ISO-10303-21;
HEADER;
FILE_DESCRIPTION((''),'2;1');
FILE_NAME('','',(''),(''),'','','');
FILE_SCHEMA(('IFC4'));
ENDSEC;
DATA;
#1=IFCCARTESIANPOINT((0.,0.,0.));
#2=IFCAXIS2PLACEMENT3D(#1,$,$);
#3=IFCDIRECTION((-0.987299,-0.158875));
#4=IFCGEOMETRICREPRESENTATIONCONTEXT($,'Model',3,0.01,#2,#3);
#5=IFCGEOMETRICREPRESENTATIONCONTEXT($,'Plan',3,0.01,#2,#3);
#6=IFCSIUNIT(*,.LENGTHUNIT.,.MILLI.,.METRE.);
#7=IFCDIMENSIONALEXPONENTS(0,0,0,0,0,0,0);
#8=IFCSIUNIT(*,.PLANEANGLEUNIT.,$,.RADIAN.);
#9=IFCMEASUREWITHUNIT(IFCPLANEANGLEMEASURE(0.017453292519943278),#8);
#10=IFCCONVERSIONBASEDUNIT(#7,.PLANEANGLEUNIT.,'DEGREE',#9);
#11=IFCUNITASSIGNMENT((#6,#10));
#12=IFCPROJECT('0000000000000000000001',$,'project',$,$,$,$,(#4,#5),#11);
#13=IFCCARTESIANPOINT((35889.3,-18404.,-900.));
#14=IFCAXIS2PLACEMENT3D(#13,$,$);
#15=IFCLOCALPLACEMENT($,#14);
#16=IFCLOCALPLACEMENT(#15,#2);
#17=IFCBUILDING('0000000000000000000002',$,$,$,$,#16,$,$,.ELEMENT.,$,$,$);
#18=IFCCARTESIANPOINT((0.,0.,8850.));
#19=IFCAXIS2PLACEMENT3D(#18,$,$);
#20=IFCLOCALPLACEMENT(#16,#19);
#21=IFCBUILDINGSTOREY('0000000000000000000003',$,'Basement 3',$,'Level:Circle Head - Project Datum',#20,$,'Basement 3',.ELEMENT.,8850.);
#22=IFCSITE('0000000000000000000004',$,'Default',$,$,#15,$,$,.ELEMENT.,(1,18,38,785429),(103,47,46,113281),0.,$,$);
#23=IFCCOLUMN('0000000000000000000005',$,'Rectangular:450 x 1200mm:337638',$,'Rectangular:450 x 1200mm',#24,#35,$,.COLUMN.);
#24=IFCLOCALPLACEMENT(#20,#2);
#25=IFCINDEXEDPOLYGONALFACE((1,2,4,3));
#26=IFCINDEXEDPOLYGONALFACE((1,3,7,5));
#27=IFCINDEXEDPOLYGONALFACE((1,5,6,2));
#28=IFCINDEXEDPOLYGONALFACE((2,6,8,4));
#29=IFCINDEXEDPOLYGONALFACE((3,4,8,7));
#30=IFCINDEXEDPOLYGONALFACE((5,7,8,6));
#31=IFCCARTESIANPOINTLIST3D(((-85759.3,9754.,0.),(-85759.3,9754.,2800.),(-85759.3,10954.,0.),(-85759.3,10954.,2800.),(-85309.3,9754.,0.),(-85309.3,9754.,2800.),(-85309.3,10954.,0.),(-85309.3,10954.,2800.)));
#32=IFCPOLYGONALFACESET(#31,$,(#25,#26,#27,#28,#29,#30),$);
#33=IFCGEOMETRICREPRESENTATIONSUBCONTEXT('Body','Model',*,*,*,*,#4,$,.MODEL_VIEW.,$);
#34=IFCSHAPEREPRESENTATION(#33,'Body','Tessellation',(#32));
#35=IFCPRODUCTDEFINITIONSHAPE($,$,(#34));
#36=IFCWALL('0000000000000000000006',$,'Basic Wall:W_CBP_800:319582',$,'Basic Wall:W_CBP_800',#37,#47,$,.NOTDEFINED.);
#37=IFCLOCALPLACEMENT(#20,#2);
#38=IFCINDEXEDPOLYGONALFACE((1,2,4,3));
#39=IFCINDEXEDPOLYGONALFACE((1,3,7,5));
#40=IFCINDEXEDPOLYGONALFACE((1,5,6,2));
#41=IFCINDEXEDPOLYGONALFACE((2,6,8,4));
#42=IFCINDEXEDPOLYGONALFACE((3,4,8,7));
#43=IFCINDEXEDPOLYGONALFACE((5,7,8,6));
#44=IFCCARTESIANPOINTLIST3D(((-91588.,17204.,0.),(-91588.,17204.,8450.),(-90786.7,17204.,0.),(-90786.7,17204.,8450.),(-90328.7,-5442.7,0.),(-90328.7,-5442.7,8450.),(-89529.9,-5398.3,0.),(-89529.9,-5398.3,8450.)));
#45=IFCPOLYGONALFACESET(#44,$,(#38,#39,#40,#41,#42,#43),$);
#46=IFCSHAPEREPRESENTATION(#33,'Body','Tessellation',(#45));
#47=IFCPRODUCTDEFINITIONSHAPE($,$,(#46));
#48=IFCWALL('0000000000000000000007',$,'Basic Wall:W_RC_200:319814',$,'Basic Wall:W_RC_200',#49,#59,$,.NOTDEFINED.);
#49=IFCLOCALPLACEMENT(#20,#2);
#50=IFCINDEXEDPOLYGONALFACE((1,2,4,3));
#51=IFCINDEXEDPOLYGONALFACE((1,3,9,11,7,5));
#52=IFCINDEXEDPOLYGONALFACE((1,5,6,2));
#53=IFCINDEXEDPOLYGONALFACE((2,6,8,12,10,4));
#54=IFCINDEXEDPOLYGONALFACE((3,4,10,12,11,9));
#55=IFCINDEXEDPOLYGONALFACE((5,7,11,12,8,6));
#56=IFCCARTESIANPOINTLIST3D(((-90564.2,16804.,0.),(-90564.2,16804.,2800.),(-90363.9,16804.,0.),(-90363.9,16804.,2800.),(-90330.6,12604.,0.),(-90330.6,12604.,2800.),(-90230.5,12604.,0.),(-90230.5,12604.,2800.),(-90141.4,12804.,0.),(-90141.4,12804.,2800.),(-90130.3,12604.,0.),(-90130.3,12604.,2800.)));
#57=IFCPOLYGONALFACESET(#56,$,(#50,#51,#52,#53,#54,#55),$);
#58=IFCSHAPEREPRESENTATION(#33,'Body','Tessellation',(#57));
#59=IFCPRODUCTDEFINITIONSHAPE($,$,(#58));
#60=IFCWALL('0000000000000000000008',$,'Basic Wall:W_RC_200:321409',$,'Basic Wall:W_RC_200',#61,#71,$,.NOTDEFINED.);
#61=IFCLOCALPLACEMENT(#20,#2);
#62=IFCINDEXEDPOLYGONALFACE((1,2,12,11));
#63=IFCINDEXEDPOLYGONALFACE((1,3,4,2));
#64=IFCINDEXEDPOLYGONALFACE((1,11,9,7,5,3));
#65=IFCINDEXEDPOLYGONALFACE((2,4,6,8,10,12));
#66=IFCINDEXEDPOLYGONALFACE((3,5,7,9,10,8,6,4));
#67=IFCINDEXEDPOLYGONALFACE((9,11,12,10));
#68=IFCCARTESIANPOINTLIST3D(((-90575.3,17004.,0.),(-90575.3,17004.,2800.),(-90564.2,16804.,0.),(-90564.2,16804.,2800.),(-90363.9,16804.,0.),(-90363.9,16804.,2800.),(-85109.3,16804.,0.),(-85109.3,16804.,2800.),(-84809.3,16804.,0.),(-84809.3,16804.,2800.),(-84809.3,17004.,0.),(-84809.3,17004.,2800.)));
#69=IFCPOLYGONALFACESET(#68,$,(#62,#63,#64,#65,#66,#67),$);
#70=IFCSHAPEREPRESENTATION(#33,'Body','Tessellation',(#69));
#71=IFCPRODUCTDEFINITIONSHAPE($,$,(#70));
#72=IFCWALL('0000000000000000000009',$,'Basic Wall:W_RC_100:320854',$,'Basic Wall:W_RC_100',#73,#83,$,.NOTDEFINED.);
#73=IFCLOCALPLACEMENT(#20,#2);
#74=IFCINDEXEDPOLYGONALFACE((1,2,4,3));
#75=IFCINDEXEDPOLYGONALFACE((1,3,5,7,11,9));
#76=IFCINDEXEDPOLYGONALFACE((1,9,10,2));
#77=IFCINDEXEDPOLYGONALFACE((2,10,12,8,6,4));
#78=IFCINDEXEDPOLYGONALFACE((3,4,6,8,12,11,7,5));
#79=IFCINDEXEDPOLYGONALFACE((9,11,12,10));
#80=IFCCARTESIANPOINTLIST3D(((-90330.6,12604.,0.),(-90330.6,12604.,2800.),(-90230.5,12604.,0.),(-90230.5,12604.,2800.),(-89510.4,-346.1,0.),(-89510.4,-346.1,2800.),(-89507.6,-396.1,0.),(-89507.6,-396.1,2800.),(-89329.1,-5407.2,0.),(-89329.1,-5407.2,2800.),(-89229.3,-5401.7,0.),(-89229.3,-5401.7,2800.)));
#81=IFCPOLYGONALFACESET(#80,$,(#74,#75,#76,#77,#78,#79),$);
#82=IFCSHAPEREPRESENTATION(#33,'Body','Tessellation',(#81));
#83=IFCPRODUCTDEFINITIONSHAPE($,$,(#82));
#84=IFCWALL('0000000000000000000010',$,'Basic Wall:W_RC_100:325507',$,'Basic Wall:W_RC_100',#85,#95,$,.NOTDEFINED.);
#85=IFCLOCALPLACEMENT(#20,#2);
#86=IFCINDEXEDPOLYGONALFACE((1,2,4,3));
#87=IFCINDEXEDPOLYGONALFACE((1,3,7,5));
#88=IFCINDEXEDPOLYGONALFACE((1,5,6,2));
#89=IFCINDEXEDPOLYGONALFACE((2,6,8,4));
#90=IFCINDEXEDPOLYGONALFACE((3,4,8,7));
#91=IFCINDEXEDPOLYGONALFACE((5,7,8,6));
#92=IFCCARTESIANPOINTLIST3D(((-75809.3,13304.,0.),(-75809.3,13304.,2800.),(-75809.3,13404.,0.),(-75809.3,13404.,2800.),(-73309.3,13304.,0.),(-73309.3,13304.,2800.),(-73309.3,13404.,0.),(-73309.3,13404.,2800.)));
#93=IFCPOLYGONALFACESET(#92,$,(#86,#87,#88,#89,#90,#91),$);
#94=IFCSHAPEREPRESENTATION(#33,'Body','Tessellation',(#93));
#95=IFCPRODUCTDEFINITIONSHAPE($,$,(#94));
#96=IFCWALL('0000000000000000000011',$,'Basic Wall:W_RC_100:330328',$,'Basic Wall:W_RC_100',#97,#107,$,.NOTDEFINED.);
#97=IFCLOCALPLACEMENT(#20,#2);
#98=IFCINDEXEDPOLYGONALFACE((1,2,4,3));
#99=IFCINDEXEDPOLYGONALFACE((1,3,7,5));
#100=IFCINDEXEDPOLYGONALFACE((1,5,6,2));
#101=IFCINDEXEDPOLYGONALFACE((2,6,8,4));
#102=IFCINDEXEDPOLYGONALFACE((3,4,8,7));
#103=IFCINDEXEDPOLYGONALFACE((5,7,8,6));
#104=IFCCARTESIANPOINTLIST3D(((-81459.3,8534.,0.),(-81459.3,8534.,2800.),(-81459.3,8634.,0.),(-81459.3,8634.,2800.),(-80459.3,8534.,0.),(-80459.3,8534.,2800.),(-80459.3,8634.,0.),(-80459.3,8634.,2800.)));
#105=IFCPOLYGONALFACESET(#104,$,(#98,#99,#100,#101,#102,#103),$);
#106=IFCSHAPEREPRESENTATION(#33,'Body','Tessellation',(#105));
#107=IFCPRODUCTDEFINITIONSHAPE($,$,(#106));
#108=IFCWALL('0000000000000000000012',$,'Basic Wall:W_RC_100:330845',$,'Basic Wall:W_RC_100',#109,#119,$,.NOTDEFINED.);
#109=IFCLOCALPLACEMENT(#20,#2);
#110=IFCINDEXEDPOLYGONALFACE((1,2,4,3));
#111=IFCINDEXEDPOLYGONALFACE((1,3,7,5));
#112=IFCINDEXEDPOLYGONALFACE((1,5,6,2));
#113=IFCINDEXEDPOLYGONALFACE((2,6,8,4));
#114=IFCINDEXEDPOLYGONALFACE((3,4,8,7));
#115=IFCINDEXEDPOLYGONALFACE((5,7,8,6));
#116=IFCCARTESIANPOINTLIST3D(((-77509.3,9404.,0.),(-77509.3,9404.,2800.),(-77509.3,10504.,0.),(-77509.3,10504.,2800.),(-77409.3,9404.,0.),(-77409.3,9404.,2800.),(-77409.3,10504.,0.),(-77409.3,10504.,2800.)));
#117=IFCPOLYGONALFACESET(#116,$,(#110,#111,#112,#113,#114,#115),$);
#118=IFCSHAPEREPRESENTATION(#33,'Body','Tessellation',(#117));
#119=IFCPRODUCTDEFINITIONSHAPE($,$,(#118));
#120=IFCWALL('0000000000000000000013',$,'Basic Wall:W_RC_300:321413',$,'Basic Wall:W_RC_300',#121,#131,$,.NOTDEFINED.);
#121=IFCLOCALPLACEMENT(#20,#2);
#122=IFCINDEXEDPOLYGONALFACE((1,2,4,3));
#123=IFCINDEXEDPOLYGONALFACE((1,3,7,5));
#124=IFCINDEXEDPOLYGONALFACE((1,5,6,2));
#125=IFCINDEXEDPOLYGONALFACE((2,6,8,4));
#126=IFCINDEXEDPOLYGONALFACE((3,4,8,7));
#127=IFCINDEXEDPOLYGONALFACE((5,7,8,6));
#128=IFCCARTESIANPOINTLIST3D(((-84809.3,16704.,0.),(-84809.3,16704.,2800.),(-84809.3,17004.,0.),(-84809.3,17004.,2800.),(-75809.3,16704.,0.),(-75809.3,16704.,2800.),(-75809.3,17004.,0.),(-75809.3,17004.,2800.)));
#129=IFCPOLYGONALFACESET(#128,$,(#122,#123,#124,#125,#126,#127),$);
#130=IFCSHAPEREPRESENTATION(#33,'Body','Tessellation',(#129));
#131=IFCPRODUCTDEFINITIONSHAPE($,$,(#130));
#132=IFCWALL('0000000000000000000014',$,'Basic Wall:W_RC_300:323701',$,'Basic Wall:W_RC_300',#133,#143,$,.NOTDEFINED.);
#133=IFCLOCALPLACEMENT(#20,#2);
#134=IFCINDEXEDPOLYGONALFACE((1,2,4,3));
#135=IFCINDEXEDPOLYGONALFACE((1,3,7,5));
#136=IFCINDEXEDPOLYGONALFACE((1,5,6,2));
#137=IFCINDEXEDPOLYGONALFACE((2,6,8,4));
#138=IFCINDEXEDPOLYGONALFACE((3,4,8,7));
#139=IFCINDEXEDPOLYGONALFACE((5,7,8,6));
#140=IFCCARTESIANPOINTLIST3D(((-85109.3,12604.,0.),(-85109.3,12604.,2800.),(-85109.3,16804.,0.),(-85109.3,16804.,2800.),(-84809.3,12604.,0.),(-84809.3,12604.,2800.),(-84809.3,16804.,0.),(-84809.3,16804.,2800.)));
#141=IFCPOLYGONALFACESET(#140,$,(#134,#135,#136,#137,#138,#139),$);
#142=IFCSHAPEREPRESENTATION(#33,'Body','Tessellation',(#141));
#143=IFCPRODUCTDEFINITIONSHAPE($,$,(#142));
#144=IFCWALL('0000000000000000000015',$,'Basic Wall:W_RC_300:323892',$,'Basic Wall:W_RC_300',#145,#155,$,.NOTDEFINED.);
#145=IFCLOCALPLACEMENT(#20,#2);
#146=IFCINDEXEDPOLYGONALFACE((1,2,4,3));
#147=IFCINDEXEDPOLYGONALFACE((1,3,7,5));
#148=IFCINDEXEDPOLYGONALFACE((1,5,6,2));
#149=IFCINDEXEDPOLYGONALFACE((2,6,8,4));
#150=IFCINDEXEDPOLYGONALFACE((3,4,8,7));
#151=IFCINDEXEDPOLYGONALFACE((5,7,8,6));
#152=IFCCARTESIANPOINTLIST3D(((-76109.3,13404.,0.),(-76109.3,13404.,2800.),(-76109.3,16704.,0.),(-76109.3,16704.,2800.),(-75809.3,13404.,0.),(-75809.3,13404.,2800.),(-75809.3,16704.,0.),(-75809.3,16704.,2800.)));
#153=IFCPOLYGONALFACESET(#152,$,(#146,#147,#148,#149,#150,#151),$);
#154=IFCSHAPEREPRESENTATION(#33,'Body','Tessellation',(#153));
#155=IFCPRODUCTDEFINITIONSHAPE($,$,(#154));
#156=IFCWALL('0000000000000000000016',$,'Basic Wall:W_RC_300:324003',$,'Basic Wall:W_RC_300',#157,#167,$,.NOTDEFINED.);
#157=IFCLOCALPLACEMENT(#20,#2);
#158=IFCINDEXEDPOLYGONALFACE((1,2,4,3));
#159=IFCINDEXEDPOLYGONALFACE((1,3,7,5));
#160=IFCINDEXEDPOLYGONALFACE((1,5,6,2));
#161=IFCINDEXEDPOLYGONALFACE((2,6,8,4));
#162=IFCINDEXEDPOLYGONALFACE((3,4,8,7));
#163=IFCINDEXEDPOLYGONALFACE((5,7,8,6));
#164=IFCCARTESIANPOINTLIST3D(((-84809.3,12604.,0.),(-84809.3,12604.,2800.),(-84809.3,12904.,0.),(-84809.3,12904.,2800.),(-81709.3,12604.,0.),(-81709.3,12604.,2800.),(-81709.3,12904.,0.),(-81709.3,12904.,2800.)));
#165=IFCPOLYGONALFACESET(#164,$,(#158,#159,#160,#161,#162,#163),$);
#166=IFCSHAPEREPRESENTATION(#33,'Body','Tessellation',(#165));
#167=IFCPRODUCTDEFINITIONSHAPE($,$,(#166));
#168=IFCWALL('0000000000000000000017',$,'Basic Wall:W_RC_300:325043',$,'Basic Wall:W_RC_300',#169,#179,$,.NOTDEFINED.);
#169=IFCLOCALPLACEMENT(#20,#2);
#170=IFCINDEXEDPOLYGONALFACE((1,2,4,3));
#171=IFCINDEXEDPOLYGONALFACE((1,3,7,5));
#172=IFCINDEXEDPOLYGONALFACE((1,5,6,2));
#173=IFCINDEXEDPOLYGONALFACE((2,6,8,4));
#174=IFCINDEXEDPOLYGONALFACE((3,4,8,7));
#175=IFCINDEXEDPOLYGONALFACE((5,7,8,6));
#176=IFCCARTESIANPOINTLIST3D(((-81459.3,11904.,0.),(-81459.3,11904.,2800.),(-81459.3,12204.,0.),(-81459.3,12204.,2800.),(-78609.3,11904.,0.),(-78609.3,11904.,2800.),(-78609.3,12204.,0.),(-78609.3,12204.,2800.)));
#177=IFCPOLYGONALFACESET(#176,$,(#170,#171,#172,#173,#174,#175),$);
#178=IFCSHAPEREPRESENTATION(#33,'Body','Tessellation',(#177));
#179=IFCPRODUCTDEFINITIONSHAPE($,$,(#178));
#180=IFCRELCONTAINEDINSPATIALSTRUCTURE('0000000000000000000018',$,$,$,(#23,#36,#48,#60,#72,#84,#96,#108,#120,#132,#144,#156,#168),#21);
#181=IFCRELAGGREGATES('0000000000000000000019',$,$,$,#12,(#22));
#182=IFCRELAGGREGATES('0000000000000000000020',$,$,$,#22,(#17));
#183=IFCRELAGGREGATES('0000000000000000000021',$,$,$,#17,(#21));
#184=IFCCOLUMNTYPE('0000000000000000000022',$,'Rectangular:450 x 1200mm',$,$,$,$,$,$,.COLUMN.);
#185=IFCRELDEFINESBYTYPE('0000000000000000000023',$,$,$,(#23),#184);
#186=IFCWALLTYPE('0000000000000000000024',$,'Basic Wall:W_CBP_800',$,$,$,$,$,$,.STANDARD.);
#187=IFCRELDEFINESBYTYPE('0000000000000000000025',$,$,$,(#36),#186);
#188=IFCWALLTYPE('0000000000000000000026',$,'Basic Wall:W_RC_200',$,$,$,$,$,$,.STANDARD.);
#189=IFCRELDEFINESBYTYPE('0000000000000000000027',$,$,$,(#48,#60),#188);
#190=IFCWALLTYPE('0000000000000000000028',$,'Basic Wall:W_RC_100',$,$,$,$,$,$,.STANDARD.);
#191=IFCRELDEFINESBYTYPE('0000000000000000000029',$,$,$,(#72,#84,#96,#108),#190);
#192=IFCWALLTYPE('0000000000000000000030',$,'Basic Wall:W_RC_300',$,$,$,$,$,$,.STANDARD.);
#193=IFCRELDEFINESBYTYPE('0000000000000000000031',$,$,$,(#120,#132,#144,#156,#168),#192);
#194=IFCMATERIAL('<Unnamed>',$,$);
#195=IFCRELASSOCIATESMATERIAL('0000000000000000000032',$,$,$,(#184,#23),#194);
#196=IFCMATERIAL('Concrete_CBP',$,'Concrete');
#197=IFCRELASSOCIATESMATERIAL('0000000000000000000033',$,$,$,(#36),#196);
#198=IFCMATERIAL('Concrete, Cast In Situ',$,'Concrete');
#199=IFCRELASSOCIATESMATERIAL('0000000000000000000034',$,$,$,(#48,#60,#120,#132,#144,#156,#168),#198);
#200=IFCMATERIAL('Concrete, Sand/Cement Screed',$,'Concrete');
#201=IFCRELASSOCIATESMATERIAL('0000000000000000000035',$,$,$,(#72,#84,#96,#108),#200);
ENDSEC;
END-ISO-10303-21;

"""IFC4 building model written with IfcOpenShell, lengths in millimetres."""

from ifc_helpers import new_model, entity, si_unit, converted_unit, direction, frame, origin, place, context, subcontext, project, spatial, indexed_curve, outline, extrude, source, transform, mapped, material, type_object, type_shapes, element, save


model = new_model("IFC4")

# Units and contexts
model_context = context("Model", 3, precision=0.01, world=origin(), true_north=direction((-0.987299, -0.158875)))
plan_context = context("Plan", 3, precision=0.01, world=origin(), true_north=direction((-0.987299, -0.158875)))
body_context = subcontext(model_context, "Body", "Model", "MODEL_VIEW")
ifc_project = project(units=[si_unit("LENGTHUNIT", "METRE", prefix="MILLI"), converted_unit("PLANEANGLEUNIT", "DEGREE", entity("IfcPlaneAngleMeasure", 0.017453292519943278), si_unit("PLANEANGLEUNIT", "RADIAN"), dimensions=[0, 0, 0, 0, 0, 0, 0])], contexts=[model_context, plan_context])

# Site, building, storey
site_placement = place(None, frame((35889.3, -18404.0, -900.0)))
site = spatial("IfcSite", under=ifc_project, at=site_placement, Name="Default", CompositionType="ELEMENT", RefLatitude=(1, 18, 38, 785429), RefLongitude=(103, 47, 46, 113281), RefElevation=0.0)
building_placement = place(site_placement, origin())
building = spatial("IfcBuilding", under=site, at=building_placement, CompositionType="ELEMENT")
storey_placement = place(building_placement, frame((0.0, 0.0, 8850.0)))
storey = spatial("IfcBuildingStorey", under=building, at=storey_placement, Name="Basement 3", ObjectType="Level:Circle Head - Project Datum", LongName="Basement 3", CompositionType="ELEMENT", Elevation=8850.0)

# Column
ifc_material_1 = material(Name="<Unnamed>")
column_type = type_object("IfcColumnType", Name="Rectangular:450 x 1200mm", PredefinedType="COLUMN", material=ifc_material_1)
shared_shape = source(origin(), body_context, "Body", "SweptSolid", [
    extrude(outline(indexed_curve([(-600.0, -225.0), (600.0, -225.0), (600.0, 225.0), (-600.0, 225.0), (-600.0, -225.0)], self_intersect=False)), frame((0.0, 0.0, 8850.0), z_axis=(0.0, 0.0, 1.0), x_axis=(-1.0, 0.0, 0.0)), (0.0, 0.0, 1.0), 2800.0),
])
type_shapes(column_type, [shared_shape])
column_placement = place(storey_placement, frame((-85534.3, 10354.0, -8850.0), z_axis=(0.0, 0.0, 1.0), x_axis=(0.0, -1.0, 0.0)))
element("IfcColumn", 1, at=column_placement, inside=storey, type_object=column_type, material=ifc_material_1, Name="Rectangular:450 x 1200mm:337638", ObjectType="Rectangular:450 x 1200mm", PredefinedType="COLUMN", context=body_context, shape_type="MappedRepresentation", body=[
    mapped(shared_shape, transform((0.0, 0.0, 0.0), scale=1.0)),
])

# Walls
ifc_material_2 = material(Name="Concrete_CBP", Category="Concrete")
wall_type_1 = type_object("IfcWallType", Name="Basic Wall:W_CBP_800", PredefinedType="STANDARD")
wall_1_placement = place(storey_placement, frame((-91188.6, 17226.2, 0.0), z_axis=(0.0, 0.0, 1.0), x_axis=(0.055518, -0.998458, 0.0)))
element("IfcWall", 2, at=wall_1_placement, inside=storey, type_object=wall_type_1, material=ifc_material_2, Name="Basic Wall:W_CBP_800:319582", ObjectType="Basic Wall:W_CBP_800", PredefinedType="NOTDEFINED", context=body_context, shape_type="SweptSolid", body=[
    extrude(outline(indexed_curve([(22681.8, -400.0), (22681.8, 400.0), (44.5, 400.0), (0.0, -400.0), (22681.8, -400.0)], self_intersect=False)), origin(), (0.0, 0.0, 1.0), 8450.0),
])
ifc_material_3 = material(Name="Concrete, Cast In Situ", Category="Concrete")
wall_type_2 = type_object("IfcWallType", Name="Basic Wall:W_RC_200", PredefinedType="STANDARD")
wall_2_placement = place(storey_placement, frame((-90464.3, 16809.6, 0.0), z_axis=(0.0, 0.0, 1.0), x_axis=(0.055518, -0.998458, 0.0)))
element("IfcWall", 3, at=wall_2_placement, inside=storey, type_object=wall_type_2, material=ifc_material_3, Name="Basic Wall:W_RC_200:319814", ObjectType="Basic Wall:W_RC_200", PredefinedType="NOTDEFINED", context=body_context, shape_type="SweptSolid", body=[
    extrude(outline(indexed_curve([(4206.5, -100.0), (4212.0, 0.0), (4217.6, 100.0), (4017.3, 100.0), (11.1, 100.0), (0.0, -100.0), (4206.5, -100.0)], self_intersect=False)), origin(), (0.0, 0.0, 1.0), 2800.0),
])
wall_3_placement = place(storey_placement, frame((-84809.3, 16904.0, 0.0), z_axis=(0.0, 0.0, 1.0), x_axis=(-1.0, 0.0, 0.0)))
element("IfcWall", 4, at=wall_3_placement, inside=storey, type_object=wall_type_2, material=ifc_material_3, Name="Basic Wall:W_RC_200:321409", ObjectType="Basic Wall:W_RC_200", PredefinedType="NOTDEFINED", context=body_context, shape_type="SweptSolid", body=[
    extrude(outline(indexed_curve([(5765.9, -100.0), (5754.8, 100.0), (5554.5, 100.0), (300.0, 100.0), (0.0, 100.0), (0.0, -100.0), (5765.9, -100.0)], self_intersect=False)), origin(), (0.0, 0.0, 1.0), 2800.0),
])
ifc_material_4 = material(Name="Concrete, Sand/Cement Screed", Category="Concrete")
wall_type_3 = type_object("IfcWallType", Name="Basic Wall:W_RC_100", PredefinedType="STANDARD")
wall_4_placement = place(storey_placement, frame((-90280.7, 12606.8, 0.0), z_axis=(0.0, 0.0, 1.0), x_axis=(0.055518, -0.998458, 0.0)))
element("IfcWall", 5, at=wall_4_placement, inside=storey, type_object=wall_type_3, material=ifc_material_4, Name="Basic Wall:W_RC_100:320854", ObjectType="Basic Wall:W_RC_100", PredefinedType="NOTDEFINED", context=body_context, shape_type="SweptSolid", body=[
    extrude(outline(indexed_curve([(18039.1, -50.0), (18039.1, 50.0), (13025.8, 50.0), (12975.7, 50.0), (5.6, 50.0), (0.0, -50.0), (18039.1, -50.0)], self_intersect=False)), origin(), (0.0, 0.0, 1.0), 2800.0),
])
wall_5_placement = place(storey_placement, frame((-73309.3, 13354.0, 0.0), z_axis=(0.0, 0.0, 1.0), x_axis=(-1.0, 0.0, 0.0)))
element("IfcWall", 6, at=wall_5_placement, inside=storey, type_object=wall_type_3, material=ifc_material_4, Name="Basic Wall:W_RC_100:325507", ObjectType="Basic Wall:W_RC_100", PredefinedType="NOTDEFINED", context=body_context, shape_type="SweptSolid", body=[
    extrude(outline(indexed_curve([(2500.0, 50.0), (0.0, 50.0), (0.0, -50.0), (2500.0, -50.0), (2500.0, 50.0)], self_intersect=False)), origin(), (0.0, 0.0, 1.0), 2800.0),
])
wall_6_placement = place(storey_placement, frame((-81459.3, 8584.0, 0.0)))
element("IfcWall", 7, at=wall_6_placement, inside=storey, type_object=wall_type_3, material=ifc_material_4, Name="Basic Wall:W_RC_100:330328", ObjectType="Basic Wall:W_RC_100", PredefinedType="NOTDEFINED", context=body_context, shape_type="SweptSolid", body=[
    extrude(outline(indexed_curve([(1000.0, 50.0), (0.0, 50.0), (0.0, -50.0), (1000.0, -50.0), (1000.0, 50.0)], self_intersect=False)), origin(), (0.0, 0.0, 1.0), 2800.0),
])
wall_7_placement = place(storey_placement, frame((-77459.3, 10504.0, 0.0), z_axis=(0.0, 0.0, 1.0), x_axis=(0.0, -1.0, 0.0)))
element("IfcWall", 8, at=wall_7_placement, inside=storey, type_object=wall_type_3, material=ifc_material_4, Name="Basic Wall:W_RC_100:330845", ObjectType="Basic Wall:W_RC_100", PredefinedType="NOTDEFINED", context=body_context, shape_type="SweptSolid", body=[
    extrude(outline(indexed_curve([(1100.0, 50.0), (0.0, 50.0), (0.0, -50.0), (1100.0, -50.0), (1100.0, 50.0)], self_intersect=False)), origin(), (0.0, 0.0, 1.0), 2800.0),
])
wall_type_4 = type_object("IfcWallType", Name="Basic Wall:W_RC_300", PredefinedType="STANDARD")
wall_8_placement = place(storey_placement, frame((-75809.3, 16854.0, 0.0), z_axis=(0.0, 0.0, 1.0), x_axis=(-1.0, 0.0, 0.0)))
element("IfcWall", 9, at=wall_8_placement, inside=storey, type_object=wall_type_4, material=ifc_material_3, Name="Basic Wall:W_RC_300:321413", ObjectType="Basic Wall:W_RC_300", PredefinedType="NOTDEFINED", context=body_context, shape_type="SweptSolid", body=[
    extrude(outline(indexed_curve([(9000.0, 150.0), (0.0, 150.0), (0.0, -150.0), (9000.0, -150.0), (9000.0, 150.0)], self_intersect=False)), origin(), (0.0, 0.0, 1.0), 2800.0),
])
wall_9_placement = place(storey_placement, frame((-84959.3, 12604.0, 0.0), z_axis=(0.0, 0.0, 1.0), x_axis=(0.0, 1.0, 0.0)))
element("IfcWall", 10, at=wall_9_placement, inside=storey, type_object=wall_type_4, material=ifc_material_3, Name="Basic Wall:W_RC_300:323701", ObjectType="Basic Wall:W_RC_300", PredefinedType="NOTDEFINED", context=body_context, shape_type="SweptSolid", body=[
    extrude(outline(indexed_curve([(4200.0, 150.0), (0.0, 150.0), (0.0, -150.0), (4200.0, -150.0), (4200.0, 150.0)], self_intersect=False)), origin(), (0.0, 0.0, 1.0), 2800.0),
])
wall_10_placement = place(storey_placement, frame((-75959.3, 13404.0, 0.0), z_axis=(0.0, 0.0, 1.0), x_axis=(0.0, 1.0, 0.0)))
element("IfcWall", 11, at=wall_10_placement, inside=storey, type_object=wall_type_4, material=ifc_material_3, Name="Basic Wall:W_RC_300:323892", ObjectType="Basic Wall:W_RC_300", PredefinedType="NOTDEFINED", context=body_context, shape_type="SweptSolid", body=[
    extrude(outline(indexed_curve([(3300.0, 150.0), (0.0, 150.0), (0.0, -150.0), (3300.0, -150.0), (3300.0, 150.0)], self_intersect=False)), origin(), (0.0, 0.0, 1.0), 2800.0),
])
wall_11_placement = place(storey_placement, frame((-81709.3, 12754.0, 0.0), z_axis=(0.0, 0.0, 1.0), x_axis=(-1.0, 0.0, 0.0)))
element("IfcWall", 12, at=wall_11_placement, inside=storey, type_object=wall_type_4, material=ifc_material_3, Name="Basic Wall:W_RC_300:324003", ObjectType="Basic Wall:W_RC_300", PredefinedType="NOTDEFINED", context=body_context, shape_type="SweptSolid", body=[
    extrude(outline(indexed_curve([(3100.0, 150.0), (0.0, 150.0), (0.0, -150.0), (3100.0, -150.0), (3100.0, 150.0)], self_intersect=False)), origin(), (0.0, 0.0, 1.0), 2800.0),
])
wall_12_placement = place(storey_placement, frame((-81459.3, 12054.0, 0.0)))
element("IfcWall", 13, at=wall_12_placement, inside=storey, type_object=wall_type_4, material=ifc_material_3, Name="Basic Wall:W_RC_300:325043", ObjectType="Basic Wall:W_RC_300", PredefinedType="NOTDEFINED", context=body_context, shape_type="SweptSolid", body=[
    extrude(outline(indexed_curve([(2850.0, 150.0), (0.0, 150.0), (0.0, -150.0), (2850.0, -150.0), (2850.0, 150.0)], self_intersect=False)), origin(), (0.0, 0.0, 1.0), 2800.0),
])

save(model, "model.ifc")
